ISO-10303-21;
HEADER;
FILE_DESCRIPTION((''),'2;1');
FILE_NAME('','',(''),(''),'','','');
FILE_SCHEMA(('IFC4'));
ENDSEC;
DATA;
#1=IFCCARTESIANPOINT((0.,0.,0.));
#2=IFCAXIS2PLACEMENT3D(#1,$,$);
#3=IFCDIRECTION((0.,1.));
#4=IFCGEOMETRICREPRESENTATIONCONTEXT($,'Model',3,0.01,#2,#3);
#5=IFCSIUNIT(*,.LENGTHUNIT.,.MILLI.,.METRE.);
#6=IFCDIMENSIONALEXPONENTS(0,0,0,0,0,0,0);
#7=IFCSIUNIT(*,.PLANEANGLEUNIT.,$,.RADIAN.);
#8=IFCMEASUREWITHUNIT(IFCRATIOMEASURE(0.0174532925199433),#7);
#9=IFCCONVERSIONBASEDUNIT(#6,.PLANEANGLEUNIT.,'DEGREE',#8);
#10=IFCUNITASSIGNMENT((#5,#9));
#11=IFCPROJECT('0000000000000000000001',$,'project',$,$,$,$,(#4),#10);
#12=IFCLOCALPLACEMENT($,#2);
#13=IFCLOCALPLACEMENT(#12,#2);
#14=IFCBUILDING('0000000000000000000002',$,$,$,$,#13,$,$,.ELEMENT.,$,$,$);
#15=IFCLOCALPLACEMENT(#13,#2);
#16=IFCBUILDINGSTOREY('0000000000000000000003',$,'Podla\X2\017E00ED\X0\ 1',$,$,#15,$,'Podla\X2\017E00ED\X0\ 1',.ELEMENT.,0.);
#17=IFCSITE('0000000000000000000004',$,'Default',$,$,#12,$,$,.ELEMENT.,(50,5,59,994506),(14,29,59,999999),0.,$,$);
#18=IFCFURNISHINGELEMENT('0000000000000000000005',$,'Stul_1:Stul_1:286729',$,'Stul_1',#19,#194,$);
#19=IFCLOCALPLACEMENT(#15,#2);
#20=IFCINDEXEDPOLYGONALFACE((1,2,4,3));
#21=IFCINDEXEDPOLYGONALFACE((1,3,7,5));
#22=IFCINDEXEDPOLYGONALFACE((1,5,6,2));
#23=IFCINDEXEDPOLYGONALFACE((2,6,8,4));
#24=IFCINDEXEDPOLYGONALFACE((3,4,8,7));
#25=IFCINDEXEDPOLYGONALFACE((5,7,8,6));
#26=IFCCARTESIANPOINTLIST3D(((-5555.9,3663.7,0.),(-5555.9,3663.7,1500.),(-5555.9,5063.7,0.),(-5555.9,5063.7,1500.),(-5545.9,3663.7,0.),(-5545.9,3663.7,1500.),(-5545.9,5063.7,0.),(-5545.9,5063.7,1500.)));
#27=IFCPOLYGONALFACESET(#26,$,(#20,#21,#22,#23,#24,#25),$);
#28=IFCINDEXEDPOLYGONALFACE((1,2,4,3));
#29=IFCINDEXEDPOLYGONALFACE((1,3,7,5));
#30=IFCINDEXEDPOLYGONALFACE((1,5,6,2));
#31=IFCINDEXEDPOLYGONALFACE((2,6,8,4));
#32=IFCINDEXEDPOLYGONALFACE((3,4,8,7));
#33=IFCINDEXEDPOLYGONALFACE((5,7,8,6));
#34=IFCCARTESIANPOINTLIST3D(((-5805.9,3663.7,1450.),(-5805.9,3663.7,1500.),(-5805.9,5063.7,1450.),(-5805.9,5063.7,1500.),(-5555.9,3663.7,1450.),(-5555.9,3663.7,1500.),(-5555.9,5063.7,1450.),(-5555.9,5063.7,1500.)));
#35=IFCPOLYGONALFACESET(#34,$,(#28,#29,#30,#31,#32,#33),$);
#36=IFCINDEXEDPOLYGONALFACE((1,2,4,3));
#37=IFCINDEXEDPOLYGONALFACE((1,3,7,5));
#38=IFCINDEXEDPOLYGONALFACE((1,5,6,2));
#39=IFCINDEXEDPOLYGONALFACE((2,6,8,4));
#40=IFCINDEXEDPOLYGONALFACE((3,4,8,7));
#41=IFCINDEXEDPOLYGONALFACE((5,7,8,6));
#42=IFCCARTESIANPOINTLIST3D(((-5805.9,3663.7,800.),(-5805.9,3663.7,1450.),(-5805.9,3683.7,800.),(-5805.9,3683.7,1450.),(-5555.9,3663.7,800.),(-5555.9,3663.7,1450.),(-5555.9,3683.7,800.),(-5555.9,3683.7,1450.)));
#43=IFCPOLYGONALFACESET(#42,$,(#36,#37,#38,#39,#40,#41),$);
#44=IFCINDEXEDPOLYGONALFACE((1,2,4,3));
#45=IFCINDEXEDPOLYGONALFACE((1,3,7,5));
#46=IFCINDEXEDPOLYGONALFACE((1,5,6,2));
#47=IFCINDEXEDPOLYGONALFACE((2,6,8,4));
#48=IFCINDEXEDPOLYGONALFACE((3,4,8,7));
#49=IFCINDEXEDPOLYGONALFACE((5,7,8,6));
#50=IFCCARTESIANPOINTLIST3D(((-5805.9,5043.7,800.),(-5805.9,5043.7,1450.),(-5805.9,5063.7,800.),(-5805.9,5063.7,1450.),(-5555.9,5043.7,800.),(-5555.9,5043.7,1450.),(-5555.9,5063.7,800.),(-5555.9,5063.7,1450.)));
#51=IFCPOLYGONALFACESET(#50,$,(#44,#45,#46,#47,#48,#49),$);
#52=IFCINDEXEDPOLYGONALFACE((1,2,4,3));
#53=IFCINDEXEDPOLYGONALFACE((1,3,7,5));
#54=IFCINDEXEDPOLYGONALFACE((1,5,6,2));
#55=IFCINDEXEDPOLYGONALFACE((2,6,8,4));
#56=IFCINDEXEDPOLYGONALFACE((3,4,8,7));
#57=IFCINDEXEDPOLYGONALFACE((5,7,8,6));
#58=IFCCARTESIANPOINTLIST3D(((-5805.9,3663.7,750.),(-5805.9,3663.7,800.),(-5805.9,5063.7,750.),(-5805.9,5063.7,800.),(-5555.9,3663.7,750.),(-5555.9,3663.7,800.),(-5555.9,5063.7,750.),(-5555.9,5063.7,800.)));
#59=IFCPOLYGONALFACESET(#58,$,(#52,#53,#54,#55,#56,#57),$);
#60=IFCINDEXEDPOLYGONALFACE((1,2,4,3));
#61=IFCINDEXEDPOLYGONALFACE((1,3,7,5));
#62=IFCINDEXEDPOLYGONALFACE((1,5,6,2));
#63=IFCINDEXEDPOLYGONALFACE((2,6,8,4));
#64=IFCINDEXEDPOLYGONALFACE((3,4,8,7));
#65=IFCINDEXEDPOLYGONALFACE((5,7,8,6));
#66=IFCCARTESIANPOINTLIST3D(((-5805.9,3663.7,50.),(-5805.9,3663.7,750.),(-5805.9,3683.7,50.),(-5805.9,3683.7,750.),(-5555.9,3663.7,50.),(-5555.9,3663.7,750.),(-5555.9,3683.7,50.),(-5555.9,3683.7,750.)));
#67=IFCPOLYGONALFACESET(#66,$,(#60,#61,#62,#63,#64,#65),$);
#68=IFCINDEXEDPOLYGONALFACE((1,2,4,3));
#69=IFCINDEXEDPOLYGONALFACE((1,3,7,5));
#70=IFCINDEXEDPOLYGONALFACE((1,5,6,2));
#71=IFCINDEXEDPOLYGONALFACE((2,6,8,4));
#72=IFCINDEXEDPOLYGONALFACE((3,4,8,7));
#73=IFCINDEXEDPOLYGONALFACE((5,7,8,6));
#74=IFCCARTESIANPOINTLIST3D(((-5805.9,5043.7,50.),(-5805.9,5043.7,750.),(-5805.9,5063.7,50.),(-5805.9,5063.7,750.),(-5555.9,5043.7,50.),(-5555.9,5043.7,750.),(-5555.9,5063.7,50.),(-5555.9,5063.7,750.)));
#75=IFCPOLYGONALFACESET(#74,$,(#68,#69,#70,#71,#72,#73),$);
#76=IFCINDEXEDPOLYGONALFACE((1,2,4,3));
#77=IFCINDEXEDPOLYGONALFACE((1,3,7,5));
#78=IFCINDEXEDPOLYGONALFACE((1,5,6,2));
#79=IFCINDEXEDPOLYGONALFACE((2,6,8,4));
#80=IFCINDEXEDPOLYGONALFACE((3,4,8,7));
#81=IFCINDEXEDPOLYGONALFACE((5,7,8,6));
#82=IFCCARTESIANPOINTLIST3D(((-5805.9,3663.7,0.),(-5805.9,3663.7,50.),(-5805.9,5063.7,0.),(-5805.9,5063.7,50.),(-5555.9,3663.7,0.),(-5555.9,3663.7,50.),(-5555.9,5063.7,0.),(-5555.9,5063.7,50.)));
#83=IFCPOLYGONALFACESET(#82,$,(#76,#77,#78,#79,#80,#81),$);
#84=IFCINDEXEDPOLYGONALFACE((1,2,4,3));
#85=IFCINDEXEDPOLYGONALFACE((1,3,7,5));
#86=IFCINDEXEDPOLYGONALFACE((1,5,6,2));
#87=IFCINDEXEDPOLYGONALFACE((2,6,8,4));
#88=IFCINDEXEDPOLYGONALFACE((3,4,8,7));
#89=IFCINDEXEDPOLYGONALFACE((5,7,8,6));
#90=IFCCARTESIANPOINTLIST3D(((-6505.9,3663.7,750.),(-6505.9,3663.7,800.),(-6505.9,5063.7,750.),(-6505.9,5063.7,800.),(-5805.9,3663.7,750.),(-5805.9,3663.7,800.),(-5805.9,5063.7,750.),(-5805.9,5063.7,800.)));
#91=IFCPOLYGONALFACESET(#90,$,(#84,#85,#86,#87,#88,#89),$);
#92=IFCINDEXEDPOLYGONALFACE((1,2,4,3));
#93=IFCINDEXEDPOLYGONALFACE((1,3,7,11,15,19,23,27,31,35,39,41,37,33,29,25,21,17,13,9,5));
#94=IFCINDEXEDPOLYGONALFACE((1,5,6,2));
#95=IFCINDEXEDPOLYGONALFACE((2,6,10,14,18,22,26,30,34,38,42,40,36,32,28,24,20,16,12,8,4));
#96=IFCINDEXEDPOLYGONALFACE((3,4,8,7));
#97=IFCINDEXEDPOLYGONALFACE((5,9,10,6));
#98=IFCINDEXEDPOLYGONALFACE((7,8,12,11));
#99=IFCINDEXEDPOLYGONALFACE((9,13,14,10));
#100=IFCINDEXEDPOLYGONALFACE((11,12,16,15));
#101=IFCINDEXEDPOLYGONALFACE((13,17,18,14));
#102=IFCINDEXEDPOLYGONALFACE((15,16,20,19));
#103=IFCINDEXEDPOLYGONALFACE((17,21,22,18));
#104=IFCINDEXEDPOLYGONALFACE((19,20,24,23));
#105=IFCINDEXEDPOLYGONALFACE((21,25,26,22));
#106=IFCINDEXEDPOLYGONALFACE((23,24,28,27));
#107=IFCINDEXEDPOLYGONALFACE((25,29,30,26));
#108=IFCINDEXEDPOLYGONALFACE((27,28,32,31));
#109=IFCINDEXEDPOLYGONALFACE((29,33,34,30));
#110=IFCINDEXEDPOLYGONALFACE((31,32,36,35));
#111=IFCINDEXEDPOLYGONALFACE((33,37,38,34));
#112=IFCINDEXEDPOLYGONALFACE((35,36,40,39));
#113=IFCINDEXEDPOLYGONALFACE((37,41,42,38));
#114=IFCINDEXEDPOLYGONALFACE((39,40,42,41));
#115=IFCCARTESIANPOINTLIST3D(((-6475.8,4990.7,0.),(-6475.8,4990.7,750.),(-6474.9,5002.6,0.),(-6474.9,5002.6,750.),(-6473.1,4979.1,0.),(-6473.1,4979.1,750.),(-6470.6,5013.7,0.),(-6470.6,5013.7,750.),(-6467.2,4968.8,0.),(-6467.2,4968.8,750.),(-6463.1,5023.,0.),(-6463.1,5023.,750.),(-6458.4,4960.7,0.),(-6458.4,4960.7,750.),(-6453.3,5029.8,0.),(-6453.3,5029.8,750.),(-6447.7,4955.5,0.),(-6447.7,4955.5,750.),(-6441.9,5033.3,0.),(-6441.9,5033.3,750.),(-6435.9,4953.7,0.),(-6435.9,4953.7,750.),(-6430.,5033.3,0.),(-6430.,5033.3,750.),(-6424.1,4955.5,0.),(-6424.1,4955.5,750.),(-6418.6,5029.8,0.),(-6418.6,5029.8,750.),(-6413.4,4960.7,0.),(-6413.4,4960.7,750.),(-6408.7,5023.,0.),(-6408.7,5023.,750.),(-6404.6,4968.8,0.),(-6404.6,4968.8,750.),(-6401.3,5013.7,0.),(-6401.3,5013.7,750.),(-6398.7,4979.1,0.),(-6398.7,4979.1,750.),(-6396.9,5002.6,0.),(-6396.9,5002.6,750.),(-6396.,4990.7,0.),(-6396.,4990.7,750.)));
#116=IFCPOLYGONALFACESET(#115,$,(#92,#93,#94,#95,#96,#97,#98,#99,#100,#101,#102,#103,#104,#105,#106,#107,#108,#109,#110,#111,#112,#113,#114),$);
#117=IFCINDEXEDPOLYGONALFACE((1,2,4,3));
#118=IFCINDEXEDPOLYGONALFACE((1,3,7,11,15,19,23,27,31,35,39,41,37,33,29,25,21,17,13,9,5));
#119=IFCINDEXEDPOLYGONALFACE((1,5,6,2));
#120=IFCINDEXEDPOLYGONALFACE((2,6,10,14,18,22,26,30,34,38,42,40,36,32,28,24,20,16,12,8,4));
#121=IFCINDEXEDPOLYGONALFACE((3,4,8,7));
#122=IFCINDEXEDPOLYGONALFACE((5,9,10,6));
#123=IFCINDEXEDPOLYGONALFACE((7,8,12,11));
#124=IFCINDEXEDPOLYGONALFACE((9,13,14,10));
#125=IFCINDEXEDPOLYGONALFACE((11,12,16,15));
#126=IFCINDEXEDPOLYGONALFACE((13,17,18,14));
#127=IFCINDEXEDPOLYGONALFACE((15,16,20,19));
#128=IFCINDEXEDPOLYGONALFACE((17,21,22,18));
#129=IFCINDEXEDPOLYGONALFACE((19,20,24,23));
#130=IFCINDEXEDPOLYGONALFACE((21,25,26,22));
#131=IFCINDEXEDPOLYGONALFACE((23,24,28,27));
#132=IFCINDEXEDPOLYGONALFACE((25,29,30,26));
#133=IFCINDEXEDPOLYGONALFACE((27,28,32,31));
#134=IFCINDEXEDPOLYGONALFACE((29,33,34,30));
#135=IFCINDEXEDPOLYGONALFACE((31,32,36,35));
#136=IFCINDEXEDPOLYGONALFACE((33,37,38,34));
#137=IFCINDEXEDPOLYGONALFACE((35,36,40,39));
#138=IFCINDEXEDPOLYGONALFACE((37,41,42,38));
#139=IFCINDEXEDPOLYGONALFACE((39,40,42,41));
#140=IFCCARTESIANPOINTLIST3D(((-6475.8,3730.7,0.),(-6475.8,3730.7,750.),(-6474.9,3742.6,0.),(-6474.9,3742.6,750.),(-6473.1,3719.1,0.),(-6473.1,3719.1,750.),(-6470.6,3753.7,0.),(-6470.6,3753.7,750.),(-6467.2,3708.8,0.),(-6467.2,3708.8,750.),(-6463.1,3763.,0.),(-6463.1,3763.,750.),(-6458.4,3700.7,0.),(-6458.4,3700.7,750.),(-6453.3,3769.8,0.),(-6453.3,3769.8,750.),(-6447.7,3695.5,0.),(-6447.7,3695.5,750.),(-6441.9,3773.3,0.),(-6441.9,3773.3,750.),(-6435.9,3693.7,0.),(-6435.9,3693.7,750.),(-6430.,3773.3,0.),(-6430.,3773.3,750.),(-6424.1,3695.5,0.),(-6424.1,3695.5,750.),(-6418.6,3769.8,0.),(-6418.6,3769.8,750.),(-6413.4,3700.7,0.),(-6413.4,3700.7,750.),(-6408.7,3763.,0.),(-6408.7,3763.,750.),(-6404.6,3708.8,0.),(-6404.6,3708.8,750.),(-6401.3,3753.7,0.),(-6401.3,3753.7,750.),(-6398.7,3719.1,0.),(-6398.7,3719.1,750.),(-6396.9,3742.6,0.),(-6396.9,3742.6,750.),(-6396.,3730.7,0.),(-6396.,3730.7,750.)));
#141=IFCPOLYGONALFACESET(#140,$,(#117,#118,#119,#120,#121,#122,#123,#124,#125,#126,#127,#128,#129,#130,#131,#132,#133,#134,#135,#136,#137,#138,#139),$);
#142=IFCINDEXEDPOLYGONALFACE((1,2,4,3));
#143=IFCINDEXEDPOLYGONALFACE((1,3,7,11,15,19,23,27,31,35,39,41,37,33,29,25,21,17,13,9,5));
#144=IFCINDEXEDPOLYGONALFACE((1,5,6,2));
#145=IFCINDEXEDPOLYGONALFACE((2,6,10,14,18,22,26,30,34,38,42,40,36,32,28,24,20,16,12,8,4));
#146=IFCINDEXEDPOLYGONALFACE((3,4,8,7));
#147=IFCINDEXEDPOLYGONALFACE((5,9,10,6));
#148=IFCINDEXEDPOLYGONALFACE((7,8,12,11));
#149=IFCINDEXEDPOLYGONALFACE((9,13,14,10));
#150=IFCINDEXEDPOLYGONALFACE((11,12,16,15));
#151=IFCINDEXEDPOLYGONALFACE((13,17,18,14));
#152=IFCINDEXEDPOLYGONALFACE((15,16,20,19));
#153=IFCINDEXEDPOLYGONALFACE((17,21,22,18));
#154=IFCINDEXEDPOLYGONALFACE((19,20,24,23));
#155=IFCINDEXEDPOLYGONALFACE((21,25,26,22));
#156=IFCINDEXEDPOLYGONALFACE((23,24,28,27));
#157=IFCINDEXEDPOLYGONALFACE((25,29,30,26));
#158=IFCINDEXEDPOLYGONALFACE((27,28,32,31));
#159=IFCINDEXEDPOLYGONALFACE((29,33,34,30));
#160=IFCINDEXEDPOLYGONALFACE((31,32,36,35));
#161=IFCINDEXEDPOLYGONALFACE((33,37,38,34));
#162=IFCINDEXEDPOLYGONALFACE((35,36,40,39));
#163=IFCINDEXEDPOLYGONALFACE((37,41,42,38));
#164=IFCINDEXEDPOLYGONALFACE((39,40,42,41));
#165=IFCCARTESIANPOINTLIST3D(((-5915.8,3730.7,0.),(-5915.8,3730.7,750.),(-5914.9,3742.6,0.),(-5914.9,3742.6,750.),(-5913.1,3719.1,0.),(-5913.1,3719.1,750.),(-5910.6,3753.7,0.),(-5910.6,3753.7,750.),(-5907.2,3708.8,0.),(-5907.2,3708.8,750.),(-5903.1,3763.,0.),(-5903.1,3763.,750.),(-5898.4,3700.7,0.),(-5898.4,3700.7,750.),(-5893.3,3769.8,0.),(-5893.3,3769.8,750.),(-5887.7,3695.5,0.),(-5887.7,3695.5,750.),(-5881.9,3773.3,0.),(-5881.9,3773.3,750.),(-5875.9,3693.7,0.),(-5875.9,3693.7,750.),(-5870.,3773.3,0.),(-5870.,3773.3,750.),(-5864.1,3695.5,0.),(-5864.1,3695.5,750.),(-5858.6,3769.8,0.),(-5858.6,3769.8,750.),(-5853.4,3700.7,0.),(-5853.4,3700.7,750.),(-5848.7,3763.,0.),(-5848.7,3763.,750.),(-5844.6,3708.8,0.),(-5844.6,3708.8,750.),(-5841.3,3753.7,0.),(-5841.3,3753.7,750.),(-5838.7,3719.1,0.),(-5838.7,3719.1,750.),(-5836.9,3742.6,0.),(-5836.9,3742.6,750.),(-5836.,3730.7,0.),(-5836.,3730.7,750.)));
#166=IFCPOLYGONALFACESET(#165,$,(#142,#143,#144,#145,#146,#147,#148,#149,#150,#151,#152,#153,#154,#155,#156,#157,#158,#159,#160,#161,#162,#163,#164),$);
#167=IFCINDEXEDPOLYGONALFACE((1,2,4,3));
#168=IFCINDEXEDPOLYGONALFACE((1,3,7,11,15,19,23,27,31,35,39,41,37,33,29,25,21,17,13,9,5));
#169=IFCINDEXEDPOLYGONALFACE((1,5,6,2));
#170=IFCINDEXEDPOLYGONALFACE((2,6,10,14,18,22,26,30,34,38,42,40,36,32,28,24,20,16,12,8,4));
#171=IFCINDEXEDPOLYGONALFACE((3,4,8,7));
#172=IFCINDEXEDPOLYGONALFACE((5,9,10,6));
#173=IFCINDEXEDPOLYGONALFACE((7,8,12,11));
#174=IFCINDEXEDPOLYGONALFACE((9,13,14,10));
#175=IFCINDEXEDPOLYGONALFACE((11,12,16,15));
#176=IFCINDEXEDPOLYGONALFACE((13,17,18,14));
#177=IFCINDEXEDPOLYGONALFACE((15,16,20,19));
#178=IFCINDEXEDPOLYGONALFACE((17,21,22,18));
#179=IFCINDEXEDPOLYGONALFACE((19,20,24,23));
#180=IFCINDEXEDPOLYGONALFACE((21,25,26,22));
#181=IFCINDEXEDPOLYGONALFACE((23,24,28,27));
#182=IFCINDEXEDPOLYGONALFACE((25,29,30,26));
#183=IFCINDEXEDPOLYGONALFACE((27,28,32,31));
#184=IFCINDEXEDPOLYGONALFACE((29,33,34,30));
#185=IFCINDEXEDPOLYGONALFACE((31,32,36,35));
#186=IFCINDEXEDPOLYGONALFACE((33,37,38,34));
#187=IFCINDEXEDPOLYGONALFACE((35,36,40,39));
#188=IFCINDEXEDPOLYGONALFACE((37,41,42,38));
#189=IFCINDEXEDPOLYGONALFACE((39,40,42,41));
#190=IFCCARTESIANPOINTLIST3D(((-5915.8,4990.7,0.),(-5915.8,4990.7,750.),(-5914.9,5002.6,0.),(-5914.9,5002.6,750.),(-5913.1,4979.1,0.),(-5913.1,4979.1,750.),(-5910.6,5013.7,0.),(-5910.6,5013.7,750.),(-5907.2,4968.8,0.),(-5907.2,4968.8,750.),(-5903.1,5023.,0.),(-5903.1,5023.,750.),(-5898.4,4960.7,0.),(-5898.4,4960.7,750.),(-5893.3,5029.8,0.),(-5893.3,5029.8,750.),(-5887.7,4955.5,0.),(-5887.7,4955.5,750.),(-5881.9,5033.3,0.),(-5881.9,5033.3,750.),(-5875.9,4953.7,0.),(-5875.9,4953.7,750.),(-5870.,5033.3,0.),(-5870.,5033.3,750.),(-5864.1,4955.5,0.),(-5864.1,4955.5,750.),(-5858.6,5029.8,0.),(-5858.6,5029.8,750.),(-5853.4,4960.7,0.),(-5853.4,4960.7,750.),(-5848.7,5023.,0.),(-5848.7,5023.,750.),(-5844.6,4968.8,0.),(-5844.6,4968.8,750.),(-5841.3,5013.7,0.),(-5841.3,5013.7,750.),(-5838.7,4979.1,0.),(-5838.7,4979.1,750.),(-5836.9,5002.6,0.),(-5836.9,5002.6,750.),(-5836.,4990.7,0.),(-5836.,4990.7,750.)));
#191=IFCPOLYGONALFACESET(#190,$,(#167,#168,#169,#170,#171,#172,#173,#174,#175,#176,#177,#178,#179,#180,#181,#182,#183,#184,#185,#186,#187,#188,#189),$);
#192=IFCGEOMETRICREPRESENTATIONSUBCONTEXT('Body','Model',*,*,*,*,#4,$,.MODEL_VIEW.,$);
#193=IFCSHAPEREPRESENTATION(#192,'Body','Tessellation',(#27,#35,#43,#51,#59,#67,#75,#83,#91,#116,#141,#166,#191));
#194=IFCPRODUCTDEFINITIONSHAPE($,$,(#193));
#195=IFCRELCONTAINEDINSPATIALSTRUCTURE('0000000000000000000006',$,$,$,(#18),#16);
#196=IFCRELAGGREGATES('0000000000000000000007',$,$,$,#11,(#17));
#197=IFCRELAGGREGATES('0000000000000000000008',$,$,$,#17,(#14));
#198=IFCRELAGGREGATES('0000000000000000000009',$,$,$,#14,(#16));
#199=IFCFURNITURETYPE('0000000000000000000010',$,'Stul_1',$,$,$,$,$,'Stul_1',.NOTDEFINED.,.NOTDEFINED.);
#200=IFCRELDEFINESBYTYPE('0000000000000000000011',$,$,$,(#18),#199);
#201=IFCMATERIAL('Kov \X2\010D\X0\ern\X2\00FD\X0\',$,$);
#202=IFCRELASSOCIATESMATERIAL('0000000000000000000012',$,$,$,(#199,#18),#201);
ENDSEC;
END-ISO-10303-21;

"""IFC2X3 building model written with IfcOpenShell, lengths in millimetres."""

from ifc_helpers import new_model, entity, si_unit, converted_unit, direction, frame, frame_2d, origin, origin_2d_with_axis, place, context, subcontext, project, spatial, rectangle, circle, extrude, source, transform, mapped, material, type_object, type_shapes, element, save


model = new_model("IFC2X3")

# Units and contexts
model_context = context("Model", 3, precision=0.01, world=origin(), true_north=direction((0.0, 1.0)))
body_context = subcontext(model_context, "Body", "Model", "MODEL_VIEW")
ifc_project = project(units=[si_unit("LENGTHUNIT", "METRE", prefix="MILLI"), converted_unit("PLANEANGLEUNIT", "DEGREE", entity("IfcRatioMeasure", 0.0174532925199433), si_unit("PLANEANGLEUNIT", "RADIAN"), dimensions=[0, 0, 0, 0, 0, 0, 0])], contexts=[model_context])

# Site, building, storey
site_placement = place(None, origin())
site = spatial("IfcSite", under=ifc_project, at=site_placement, Name="Default", CompositionType="ELEMENT", RefLatitude=(50, 5, 59, 994506), RefLongitude=(14, 29, 59, 999999), RefElevation=0.0)
building_placement = place(site_placement, origin())
building = spatial("IfcBuilding", under=site, at=building_placement, CompositionType="ELEMENT")
storey_placement = place(building_placement, origin())
storey = spatial("IfcBuildingStorey", under=building, at=storey_placement, Name="Podlaží 1", LongName="Podlaží 1", CompositionType="ELEMENT", Elevation=0.0)

# Furnishing element
ifc_material_1 = material(Name="Kov černý")
furniture_type = type_object("IfcFurnitureType", Name="Stul_1", ElementType="Stul_1", material=ifc_material_1)
shared_shape_1 = source(origin(), body_context, "Body", "SweptSolid", [
    extrude(rectangle(XDim=1400.0, YDim=10.0, at=origin_2d_with_axis()), frame((0.0, 605.0, 0.0), z_axis=(0.0, 0.0, 1.0), x_axis=(-1.0, 0.0, 0.0)), (0.0, 0.0, 1.0), 1500.0),
    extrude(rectangle(XDim=1400.0, YDim=250.0, at=frame_2d((0.0, 0.0), x_axis=(1.0, 0.0))), frame((0.0, 475.0, 1450.0), z_axis=(0.0, 0.0, 1.0), x_axis=(-1.0, 0.0, 0.0)), (0.0, 0.0, 1.0), 50.0),
    extrude(rectangle(XDim=20.0, YDim=250.0, at=origin_2d_with_axis()), frame((690.0, 475.0, 800.0), z_axis=(0.0, 0.0, 1.0), x_axis=(-1.0, 0.0, 0.0)), (0.0, 0.0, 1.0), 650.0),
    extrude(rectangle(XDim=20.0, YDim=250.0, at=frame_2d((0.0, 0.0), x_axis=(1.0, 0.0))), frame((-690.0, 475.0, 800.0), z_axis=(0.0, 0.0, 1.0), x_axis=(-1.0, 0.0, 0.0)), (0.0, 0.0, 1.0), 650.0),
    extrude(rectangle(XDim=1400.0, YDim=250.0, at=origin_2d_with_axis()), frame((0.0, 475.0, 750.0), z_axis=(0.0, 0.0, 1.0), x_axis=(-1.0, 0.0, 0.0)), (0.0, 0.0, 1.0), 50.0),
    extrude(rectangle(XDim=20.0, YDim=250.0, at=origin_2d_with_axis()), frame((690.0, 475.0, 50.0), z_axis=(0.0, 0.0, 1.0), x_axis=(-1.0, 0.0, 0.0)), (0.0, 0.0, 1.0), 700.0),
    extrude(rectangle(XDim=20.0, YDim=250.0, at=frame_2d((0.0, 0.0), x_axis=(1.0, 0.0))), frame((-690.0, 475.0, 50.0), z_axis=(0.0, 0.0, 1.0), x_axis=(-1.0, 0.0, 0.0)), (0.0, 0.0, 1.0), 700.0),
    extrude(rectangle(XDim=1400.0, YDim=250.0, at=origin_2d_with_axis()), frame((0.0, 475.0, 0.0), z_axis=(0.0, 0.0, 1.0), x_axis=(-1.0, 0.0, 0.0)), (0.0, 0.0, 1.0), 50.0),
    extrude(rectangle(XDim=1400.0, YDim=700.0, at=origin_2d_with_axis()), frame((0.0, 0.0, 750.0), z_axis=(0.0, 0.0, 1.0), x_axis=(-1.0, 0.0, 0.0)), (0.0, 0.0, 1.0), 50.0),
    extrude(circle(Radius=40.0, at=frame_2d((0.0, 0.0), x_axis=(1.0, 0.0))), frame((-630.0, -280.0, 0.0)), (0.0, 0.0, 1.0), 750.0),
    extrude(circle(Radius=40.0, at=frame_2d((0.0, 0.0), x_axis=(1.0, 0.0))), frame((630.0, -280.0, 0.0)), (0.0, 0.0, 1.0), 750.0),
    extrude(circle(Radius=40.0, at=frame_2d((0.0, 0.0), x_axis=(1.0, 0.0))), frame((630.0, 280.0, 0.0)), (0.0, 0.0, 1.0), 750.0),
    extrude(circle(Radius=40.0, at=frame_2d((0.0, 0.0), x_axis=(1.0, 0.0))), frame((-630.0, 280.0, 0.0)), (0.0, 0.0, 1.0), 750.0),
])
type_shapes(furniture_type, [shared_shape_1])
for number, where, z_axis, x_axis, name in (
    (1, (-6155.9, 4363.7, 0.0), (0.0, 0.0, 1.0), (0.0, -1.0, 0.0), "Stul_1:Stul_1:286729"),
):
    element("IfcFurnishingElement", number, at=place(storey_placement, frame(where, z_axis=z_axis, x_axis=x_axis)), inside=storey, type_object=furniture_type, material=ifc_material_1, Name=name, ObjectType="Stul_1", context=body_context, shape_type="MappedRepresentation", body=[
        mapped(shared_shape_1, transform((0.0, 0.0, 0.0), scale=1.0)),
    ])

save(model, "model.ifc")
